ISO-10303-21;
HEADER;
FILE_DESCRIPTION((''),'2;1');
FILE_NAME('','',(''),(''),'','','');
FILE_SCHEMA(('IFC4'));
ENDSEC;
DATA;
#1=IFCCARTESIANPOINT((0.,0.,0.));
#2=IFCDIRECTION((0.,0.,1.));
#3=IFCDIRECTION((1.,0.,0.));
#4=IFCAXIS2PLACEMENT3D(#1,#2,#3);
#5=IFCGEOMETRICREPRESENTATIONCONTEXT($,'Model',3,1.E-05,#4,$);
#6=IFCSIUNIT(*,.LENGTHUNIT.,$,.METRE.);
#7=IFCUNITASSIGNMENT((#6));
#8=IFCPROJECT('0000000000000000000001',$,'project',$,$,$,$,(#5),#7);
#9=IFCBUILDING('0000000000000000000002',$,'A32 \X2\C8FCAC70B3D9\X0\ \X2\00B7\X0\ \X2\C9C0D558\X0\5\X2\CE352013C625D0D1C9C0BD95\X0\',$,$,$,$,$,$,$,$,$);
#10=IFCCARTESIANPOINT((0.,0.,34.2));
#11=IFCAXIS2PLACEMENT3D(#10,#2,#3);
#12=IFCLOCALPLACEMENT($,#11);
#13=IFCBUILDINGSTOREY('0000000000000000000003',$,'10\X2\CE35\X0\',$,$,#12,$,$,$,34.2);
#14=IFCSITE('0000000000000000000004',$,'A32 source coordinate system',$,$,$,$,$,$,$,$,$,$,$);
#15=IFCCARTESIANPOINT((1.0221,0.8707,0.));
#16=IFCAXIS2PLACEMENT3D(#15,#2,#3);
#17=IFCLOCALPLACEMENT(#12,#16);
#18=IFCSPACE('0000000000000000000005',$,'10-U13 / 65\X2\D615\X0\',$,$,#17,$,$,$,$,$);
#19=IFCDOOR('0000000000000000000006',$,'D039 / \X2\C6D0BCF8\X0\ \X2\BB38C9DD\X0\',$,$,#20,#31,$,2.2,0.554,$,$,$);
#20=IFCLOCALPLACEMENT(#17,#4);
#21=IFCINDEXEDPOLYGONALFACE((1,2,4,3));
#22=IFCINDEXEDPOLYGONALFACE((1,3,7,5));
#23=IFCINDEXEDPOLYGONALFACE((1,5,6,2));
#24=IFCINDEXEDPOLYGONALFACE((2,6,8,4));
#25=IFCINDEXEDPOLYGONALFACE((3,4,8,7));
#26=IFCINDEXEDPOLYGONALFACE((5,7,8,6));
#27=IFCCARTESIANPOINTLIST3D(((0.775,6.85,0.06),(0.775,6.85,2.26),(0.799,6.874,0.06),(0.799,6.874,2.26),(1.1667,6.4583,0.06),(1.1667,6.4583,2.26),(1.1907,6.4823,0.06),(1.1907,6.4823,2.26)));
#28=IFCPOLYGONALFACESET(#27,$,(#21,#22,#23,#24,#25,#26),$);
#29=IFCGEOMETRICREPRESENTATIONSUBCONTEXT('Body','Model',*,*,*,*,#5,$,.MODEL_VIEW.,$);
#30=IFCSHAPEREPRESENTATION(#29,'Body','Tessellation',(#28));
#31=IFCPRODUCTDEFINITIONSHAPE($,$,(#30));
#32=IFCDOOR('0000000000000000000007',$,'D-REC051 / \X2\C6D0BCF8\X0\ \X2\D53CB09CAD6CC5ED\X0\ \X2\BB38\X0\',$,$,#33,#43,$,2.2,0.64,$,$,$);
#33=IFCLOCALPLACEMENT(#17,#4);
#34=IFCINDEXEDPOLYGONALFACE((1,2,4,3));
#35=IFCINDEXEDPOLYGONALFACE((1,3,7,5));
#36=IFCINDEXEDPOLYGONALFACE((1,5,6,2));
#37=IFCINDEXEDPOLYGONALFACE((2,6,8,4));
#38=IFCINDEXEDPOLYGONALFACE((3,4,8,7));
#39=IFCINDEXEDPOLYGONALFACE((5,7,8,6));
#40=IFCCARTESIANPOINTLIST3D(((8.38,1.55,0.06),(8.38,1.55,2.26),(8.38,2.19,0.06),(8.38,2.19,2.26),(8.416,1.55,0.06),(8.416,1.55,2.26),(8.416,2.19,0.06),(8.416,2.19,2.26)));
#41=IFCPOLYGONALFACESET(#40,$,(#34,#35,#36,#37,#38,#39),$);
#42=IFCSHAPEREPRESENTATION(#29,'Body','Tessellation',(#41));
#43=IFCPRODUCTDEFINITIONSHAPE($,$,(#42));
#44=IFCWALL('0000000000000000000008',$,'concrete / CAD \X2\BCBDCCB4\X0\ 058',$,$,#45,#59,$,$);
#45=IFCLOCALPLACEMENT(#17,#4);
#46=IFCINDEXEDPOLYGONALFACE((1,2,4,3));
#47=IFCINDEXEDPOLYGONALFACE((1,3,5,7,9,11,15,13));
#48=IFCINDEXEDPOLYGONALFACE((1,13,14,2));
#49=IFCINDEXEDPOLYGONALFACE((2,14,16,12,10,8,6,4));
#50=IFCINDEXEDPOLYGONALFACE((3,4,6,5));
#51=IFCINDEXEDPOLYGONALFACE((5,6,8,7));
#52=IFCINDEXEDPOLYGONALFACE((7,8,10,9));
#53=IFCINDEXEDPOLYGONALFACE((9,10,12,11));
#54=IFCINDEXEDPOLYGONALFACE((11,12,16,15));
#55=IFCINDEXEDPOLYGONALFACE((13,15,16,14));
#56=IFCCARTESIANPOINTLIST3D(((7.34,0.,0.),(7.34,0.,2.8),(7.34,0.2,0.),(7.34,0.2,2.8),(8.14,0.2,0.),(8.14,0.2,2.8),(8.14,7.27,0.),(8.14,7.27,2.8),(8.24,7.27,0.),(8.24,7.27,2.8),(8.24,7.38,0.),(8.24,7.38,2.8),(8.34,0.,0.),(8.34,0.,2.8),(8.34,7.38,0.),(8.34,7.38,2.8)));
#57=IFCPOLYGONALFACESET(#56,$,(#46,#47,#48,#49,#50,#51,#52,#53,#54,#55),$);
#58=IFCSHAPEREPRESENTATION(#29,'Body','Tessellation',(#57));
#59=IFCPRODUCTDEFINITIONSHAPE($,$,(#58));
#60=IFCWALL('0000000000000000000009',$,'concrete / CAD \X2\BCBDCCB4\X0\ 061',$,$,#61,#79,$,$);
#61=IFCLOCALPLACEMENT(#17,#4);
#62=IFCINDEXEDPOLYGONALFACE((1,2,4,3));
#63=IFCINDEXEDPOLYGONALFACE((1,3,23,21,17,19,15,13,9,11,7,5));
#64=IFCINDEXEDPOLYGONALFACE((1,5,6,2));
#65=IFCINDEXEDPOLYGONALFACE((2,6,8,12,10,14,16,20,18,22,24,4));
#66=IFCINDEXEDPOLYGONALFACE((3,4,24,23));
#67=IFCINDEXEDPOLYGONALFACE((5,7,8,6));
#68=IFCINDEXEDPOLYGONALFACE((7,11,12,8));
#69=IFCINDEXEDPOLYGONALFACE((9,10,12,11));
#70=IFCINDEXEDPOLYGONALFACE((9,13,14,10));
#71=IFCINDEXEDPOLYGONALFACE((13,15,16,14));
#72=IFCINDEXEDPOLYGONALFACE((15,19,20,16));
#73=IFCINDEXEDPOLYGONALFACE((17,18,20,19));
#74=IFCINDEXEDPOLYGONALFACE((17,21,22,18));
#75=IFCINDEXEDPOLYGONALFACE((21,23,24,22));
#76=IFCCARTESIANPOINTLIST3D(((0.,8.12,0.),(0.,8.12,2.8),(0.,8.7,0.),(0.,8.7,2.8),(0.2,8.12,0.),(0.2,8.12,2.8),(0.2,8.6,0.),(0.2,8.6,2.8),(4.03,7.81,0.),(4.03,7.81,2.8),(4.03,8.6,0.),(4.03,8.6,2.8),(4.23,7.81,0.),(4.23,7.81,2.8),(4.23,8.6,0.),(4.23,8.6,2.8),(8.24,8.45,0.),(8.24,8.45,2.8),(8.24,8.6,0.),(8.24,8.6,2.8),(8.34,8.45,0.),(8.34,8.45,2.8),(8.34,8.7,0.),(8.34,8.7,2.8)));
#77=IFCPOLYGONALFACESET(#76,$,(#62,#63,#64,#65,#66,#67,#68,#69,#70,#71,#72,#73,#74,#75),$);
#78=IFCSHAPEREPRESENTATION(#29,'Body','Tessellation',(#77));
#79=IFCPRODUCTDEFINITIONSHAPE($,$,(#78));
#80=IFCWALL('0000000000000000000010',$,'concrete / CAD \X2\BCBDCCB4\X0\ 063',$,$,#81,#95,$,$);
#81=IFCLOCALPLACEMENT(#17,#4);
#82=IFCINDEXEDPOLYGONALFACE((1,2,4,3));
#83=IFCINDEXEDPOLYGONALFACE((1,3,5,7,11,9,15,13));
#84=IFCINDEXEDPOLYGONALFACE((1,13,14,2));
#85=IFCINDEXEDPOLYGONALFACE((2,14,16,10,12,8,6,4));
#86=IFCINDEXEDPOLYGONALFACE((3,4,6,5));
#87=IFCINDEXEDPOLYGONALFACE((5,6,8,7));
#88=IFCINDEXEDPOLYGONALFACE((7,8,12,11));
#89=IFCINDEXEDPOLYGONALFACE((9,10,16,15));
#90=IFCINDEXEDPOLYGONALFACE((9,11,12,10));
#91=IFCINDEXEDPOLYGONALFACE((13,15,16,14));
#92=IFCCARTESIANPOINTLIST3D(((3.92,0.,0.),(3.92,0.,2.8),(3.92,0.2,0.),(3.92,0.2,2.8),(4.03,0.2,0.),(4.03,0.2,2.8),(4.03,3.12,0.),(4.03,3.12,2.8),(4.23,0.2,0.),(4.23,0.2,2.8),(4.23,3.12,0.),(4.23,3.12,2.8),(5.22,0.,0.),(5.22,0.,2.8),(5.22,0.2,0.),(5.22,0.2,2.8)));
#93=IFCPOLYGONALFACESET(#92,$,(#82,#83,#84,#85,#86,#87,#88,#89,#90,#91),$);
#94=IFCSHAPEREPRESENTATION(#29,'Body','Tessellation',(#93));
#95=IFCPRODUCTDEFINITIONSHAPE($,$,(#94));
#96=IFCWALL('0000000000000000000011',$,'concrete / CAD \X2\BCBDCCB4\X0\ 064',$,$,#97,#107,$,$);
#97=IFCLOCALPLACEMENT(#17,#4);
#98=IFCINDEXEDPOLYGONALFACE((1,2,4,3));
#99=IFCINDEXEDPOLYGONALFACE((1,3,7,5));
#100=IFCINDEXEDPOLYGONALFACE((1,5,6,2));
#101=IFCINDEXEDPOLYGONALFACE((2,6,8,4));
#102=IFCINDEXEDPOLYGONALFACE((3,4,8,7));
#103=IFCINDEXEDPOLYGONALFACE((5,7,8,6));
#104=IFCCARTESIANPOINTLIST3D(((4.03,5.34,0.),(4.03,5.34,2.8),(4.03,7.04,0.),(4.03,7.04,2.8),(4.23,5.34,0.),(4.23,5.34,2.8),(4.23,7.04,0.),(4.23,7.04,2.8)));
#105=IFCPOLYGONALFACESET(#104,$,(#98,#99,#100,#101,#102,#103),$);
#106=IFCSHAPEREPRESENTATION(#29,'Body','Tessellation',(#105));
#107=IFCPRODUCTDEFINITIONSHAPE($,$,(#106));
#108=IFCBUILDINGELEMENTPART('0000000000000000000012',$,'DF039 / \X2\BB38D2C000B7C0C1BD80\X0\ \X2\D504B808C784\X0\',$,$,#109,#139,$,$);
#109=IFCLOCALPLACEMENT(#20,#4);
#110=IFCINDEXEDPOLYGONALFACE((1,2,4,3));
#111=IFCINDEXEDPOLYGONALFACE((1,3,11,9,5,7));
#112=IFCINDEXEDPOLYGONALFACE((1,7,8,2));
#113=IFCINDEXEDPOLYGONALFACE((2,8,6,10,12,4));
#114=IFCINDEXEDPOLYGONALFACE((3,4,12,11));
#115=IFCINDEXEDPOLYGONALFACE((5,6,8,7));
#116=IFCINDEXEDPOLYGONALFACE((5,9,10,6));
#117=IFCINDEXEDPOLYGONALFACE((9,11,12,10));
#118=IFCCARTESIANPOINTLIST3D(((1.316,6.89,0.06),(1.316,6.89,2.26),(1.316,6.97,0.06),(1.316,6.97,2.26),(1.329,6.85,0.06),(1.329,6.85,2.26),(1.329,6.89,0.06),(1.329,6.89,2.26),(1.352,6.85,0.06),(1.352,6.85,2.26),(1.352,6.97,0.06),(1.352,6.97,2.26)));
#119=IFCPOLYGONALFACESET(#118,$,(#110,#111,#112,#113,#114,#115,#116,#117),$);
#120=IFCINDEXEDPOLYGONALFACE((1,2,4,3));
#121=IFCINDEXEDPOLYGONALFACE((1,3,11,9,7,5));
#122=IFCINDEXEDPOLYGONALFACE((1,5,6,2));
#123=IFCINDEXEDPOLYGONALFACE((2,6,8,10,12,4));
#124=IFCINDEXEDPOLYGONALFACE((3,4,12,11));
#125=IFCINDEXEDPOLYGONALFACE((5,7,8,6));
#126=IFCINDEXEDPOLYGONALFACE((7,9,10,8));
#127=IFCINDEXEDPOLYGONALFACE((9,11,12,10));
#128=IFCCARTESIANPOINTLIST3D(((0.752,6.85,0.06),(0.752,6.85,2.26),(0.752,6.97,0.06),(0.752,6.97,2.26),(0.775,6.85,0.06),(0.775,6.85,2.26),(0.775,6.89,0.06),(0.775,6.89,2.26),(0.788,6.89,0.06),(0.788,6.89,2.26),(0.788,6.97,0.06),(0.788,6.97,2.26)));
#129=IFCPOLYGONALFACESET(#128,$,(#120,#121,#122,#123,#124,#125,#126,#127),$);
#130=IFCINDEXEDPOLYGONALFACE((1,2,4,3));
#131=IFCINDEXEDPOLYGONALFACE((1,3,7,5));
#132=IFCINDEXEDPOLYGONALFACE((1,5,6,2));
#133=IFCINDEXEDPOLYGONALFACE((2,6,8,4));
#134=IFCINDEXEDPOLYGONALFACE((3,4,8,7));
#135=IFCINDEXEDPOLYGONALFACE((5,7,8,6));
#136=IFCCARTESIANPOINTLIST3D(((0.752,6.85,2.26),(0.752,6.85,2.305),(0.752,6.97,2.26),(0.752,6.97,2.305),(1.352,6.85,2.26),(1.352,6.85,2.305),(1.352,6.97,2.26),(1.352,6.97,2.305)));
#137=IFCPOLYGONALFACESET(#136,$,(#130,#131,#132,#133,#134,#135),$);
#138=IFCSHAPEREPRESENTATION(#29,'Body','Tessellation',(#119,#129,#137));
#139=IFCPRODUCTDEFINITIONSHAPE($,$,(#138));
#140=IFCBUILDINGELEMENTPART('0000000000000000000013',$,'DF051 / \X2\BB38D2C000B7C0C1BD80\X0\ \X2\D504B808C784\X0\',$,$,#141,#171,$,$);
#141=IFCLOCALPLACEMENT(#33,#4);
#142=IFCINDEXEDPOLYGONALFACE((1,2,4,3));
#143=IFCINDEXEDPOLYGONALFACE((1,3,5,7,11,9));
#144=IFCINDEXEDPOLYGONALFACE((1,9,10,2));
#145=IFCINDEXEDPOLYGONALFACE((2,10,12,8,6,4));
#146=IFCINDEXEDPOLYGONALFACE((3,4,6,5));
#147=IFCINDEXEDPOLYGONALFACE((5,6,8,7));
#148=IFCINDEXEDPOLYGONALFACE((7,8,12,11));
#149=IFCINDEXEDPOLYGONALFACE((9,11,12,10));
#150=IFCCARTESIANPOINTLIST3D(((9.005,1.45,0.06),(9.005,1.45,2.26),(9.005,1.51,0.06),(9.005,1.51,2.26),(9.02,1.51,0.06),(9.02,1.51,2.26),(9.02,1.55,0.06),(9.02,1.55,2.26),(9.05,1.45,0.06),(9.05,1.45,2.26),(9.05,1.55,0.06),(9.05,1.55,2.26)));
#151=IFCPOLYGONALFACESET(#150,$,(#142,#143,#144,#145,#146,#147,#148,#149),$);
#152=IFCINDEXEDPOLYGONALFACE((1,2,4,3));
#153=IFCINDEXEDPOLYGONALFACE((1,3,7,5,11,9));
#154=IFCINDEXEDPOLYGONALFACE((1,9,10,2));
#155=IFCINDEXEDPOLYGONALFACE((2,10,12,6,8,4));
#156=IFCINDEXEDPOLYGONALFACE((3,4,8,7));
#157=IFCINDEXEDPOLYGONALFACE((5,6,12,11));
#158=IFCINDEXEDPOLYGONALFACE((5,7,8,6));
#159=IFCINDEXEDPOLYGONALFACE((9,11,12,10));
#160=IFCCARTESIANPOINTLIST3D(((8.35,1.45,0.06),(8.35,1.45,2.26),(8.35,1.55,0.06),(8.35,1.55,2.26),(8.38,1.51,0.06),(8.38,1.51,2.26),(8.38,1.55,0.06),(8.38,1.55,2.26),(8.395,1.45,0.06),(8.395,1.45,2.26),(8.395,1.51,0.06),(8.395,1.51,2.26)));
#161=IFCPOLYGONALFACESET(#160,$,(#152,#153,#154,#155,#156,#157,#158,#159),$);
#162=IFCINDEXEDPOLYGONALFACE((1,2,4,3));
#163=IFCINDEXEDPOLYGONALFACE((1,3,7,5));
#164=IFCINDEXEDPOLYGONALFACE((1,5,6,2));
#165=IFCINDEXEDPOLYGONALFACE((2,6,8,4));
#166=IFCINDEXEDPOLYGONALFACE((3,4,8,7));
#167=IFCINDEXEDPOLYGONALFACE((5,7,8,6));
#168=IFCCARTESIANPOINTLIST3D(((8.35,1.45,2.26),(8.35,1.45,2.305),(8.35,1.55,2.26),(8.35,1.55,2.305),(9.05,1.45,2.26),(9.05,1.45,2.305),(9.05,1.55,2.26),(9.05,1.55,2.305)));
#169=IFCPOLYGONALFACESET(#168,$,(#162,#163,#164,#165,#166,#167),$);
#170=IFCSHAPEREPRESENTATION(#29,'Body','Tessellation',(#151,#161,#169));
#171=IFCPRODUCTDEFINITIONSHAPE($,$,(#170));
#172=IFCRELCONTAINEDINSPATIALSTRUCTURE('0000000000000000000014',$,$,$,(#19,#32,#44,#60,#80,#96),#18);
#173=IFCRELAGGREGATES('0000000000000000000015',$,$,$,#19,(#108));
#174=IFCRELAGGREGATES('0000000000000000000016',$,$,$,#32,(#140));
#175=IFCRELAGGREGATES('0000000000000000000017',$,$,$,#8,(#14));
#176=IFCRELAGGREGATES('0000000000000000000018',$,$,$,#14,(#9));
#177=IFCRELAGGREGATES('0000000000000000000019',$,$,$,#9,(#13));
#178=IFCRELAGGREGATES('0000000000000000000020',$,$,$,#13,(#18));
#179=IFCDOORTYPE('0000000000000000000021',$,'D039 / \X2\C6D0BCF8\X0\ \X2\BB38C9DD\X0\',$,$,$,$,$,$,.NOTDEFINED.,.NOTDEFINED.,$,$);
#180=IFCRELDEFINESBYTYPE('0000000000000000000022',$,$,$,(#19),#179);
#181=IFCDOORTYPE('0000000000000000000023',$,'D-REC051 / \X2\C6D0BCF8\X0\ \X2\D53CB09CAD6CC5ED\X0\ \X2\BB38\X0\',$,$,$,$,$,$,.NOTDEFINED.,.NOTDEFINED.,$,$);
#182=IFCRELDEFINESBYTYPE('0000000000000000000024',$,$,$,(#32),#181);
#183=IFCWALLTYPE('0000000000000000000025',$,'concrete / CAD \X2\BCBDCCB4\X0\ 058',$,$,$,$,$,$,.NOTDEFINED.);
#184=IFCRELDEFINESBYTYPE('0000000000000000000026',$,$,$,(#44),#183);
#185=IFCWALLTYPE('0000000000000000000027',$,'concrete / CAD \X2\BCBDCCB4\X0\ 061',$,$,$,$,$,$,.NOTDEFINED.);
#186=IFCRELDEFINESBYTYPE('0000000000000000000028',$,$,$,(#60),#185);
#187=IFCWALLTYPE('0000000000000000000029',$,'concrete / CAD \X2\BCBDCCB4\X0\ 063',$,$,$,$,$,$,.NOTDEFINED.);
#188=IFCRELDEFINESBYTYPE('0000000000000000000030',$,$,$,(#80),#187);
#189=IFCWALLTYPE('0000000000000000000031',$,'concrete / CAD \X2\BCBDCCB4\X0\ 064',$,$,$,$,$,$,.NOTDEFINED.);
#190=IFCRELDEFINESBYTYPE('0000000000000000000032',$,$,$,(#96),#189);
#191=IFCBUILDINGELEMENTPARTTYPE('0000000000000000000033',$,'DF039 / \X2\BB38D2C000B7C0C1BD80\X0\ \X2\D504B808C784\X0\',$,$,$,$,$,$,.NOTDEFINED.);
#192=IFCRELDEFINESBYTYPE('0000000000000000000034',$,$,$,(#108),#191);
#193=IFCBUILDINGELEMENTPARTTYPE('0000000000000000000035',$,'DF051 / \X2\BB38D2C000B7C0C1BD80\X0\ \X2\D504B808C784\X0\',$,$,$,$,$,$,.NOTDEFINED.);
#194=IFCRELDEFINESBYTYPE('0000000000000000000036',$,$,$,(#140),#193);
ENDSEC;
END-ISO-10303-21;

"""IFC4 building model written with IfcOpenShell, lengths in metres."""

from ifc_helpers import new_model, si_unit, frame, origin, origin_with_axes, place, context, subcontext, project, spatial, polyline, outline, extrude, source, transform, mapped, type_object, type_shapes, element, aggregate, save


model = new_model("IFC4")

# Units and contexts
model_context = context("Model", 3, precision=1e-05, world=origin_with_axes())
body_context = subcontext(model_context, "Body", "Model", "MODEL_VIEW")
ifc_project = project(units=[si_unit("LENGTHUNIT", "METRE")], contexts=[model_context])

# Site, building, storey, space
storey_placement = place(None, frame((0.0, 0.0, 34.2), z_axis=(0.0, 0.0, 1.0), x_axis=(1.0, 0.0, 0.0)))
space_placement = place(storey_placement, frame((1.0221, 0.8707, 0.0), z_axis=(0.0, 0.0, 1.0), x_axis=(1.0, 0.0, 0.0)))
site = spatial("IfcSite", under=ifc_project, Name="A32 source coordinate system")
building = spatial("IfcBuilding", under=site, Name="A32 주거동 · 지하5층–옥탑지붕")
storey = spatial("IfcBuildingStorey", under=building, at=storey_placement, Name="10층", Elevation=34.2)
space = spatial("IfcSpace", under=storey, at=space_placement, Name="10-U13 / 65형")

# Doors
door_type_1 = type_object("IfcDoorType", Name="D039 / 원본 문짝", OperationType="NOTDEFINED", PredefinedType="NOTDEFINED")
shared_shape_1 = source(origin(), body_context, "Body", "SweptSolid", [
    extrude(outline(polyline([(1.1907, 6.4823), (1.1667, 6.4583), (0.775, 6.85), (0.799, 6.874), (1.1907, 6.4823)])), frame((0.0, 0.0, 0.06)), (0.0, 0.0, 1.0), 2.2),
])
type_shapes(door_type_1, [shared_shape_1])
door_1_placement = place(space_placement, origin_with_axes())
door_1 = element("IfcDoor", 1, at=door_1_placement, inside=space, type_object=door_type_1, Name="D039 / 원본 문짝", OverallHeight=2.2, OverallWidth=0.554, context=body_context, shape_type="MappedRepresentation", body=[
    mapped(shared_shape_1, transform((0.0, 0.0, 0.0), scale=1.0)),
])
door_type_2 = type_object("IfcDoorType", Name="D-REC051 / 원본 피난구역 문", OperationType="NOTDEFINED", PredefinedType="NOTDEFINED")
shared_shape_2 = source(origin(), body_context, "Body", "SweptSolid", [
    extrude(outline(polyline([(8.416, 2.19), (8.416, 1.55), (8.38, 1.55), (8.38, 2.19), (8.416, 2.19)])), frame((0.0, 0.0, 0.06)), (0.0, 0.0, 1.0), 2.2),
])
type_shapes(door_type_2, [shared_shape_2])
door_2_placement = place(space_placement, origin_with_axes())
door_2 = element("IfcDoor", 2, at=door_2_placement, inside=space, type_object=door_type_2, Name="D-REC051 / 원본 피난구역 문", OverallHeight=2.2, OverallWidth=0.64, context=body_context, shape_type="MappedRepresentation", body=[
    mapped(shared_shape_2, transform((0.0, 0.0, 0.0), scale=1.0)),
])

# Walls
wall_type_1 = type_object("IfcWallType", Name="concrete / CAD 벽체 058", PredefinedType="NOTDEFINED")
shared_shape_3 = source(origin(), body_context, "Body", "SweptSolid", [
    extrude(outline(polyline([(8.34, 0.0), (7.34, 0.0), (7.34, 0.2), (8.14, 0.2), (8.14, 7.27), (8.24, 7.27), (8.24, 7.38), (8.34, 7.38), (8.34, 0.0)])), origin(), (0.0, 0.0, 1.0), 2.8),
])
type_shapes(wall_type_1, [shared_shape_3])
wall_1_placement = place(space_placement, origin_with_axes())
element("IfcWall", 3, at=wall_1_placement, inside=space, type_object=wall_type_1, Name="concrete / CAD 벽체 058", context=body_context, shape_type="MappedRepresentation", body=[
    mapped(shared_shape_3, transform((0.0, 0.0, 0.0), scale=1.0)),
])
wall_type_2 = type_object("IfcWallType", Name="concrete / CAD 벽체 061", PredefinedType="NOTDEFINED")
shared_shape_4 = source(origin(), body_context, "Body", "SweptSolid", [
    extrude(outline(polyline([(0.2, 8.6), (0.2, 8.12), (0.0, 8.12), (0.0, 8.7), (8.34, 8.7), (8.34, 8.45), (8.24, 8.45), (8.24, 8.6), (4.23, 8.6), (4.23, 7.81), (4.03, 7.81), (4.03, 8.6), (0.2, 8.6)])), origin(), (0.0, 0.0, 1.0), 2.8),
])
type_shapes(wall_type_2, [shared_shape_4])
wall_2_placement = place(space_placement, origin_with_axes())
element("IfcWall", 4, at=wall_2_placement, inside=space, type_object=wall_type_2, Name="concrete / CAD 벽체 061", context=body_context, shape_type="MappedRepresentation", body=[
    mapped(shared_shape_4, transform((0.0, 0.0, 0.0), scale=1.0)),
])
wall_type_3 = type_object("IfcWallType", Name="concrete / CAD 벽체 063", PredefinedType="NOTDEFINED")
shared_shape_5 = source(origin(), body_context, "Body", "SweptSolid", [
    extrude(outline(polyline([(5.22, 0.0), (3.92, 0.0), (3.92, 0.2), (4.03, 0.2), (4.03, 3.12), (4.23, 3.12), (4.23, 0.2), (5.22, 0.2), (5.22, 0.0)])), origin(), (0.0, 0.0, 1.0), 2.8),
])
type_shapes(wall_type_3, [shared_shape_5])
wall_3_placement = place(space_placement, origin_with_axes())
element("IfcWall", 5, at=wall_3_placement, inside=space, type_object=wall_type_3, Name="concrete / CAD 벽체 063", context=body_context, shape_type="MappedRepresentation", body=[
    mapped(shared_shape_5, transform((0.0, 0.0, 0.0), scale=1.0)),
])
wall_type_4 = type_object("IfcWallType", Name="concrete / CAD 벽체 064", PredefinedType="NOTDEFINED")
shared_shape_6 = source(origin(), body_context, "Body", "SweptSolid", [
    extrude(outline(polyline([(4.03, 7.04), (4.23, 7.04), (4.23, 5.34), (4.03, 5.34), (4.03, 7.04)])), origin(), (0.0, 0.0, 1.0), 2.8),
])
type_shapes(wall_type_4, [shared_shape_6])
wall_4_placement = place(space_placement, origin_with_axes())
element("IfcWall", 6, at=wall_4_placement, inside=space, type_object=wall_type_4, Name="concrete / CAD 벽체 064", context=body_context, shape_type="MappedRepresentation", body=[
    mapped(shared_shape_6, transform((0.0, 0.0, 0.0), scale=1.0)),
])

# Building element parts
building_element_part_type_1 = type_object("IfcBuildingElementPartType", Name="DF039 / 문틀·상부 프레임", PredefinedType="NOTDEFINED")
shared_shape_7 = source(origin(), body_context, "Body", "SweptSolid", [
    extrude(outline(polyline([(1.352, 6.85), (1.329, 6.85), (1.329, 6.89), (1.316, 6.89), (1.316, 6.97), (1.352, 6.97), (1.352, 6.85)])), frame((0.0, 0.0, 0.06)), (0.0, 0.0, 1.0), 2.2),
    extrude(outline(polyline([(0.788, 6.97), (0.788, 6.89), (0.775, 6.89), (0.775, 6.85), (0.752, 6.85), (0.752, 6.97), (0.788, 6.97)])), frame((0.0, 0.0, 0.06)), (0.0, 0.0, 1.0), 2.2),
    extrude(outline(polyline([(0.752, 6.85), (0.752, 6.97), (1.352, 6.97), (1.352, 6.85), (0.752, 6.85)])), frame((0.0, 0.0, 2.26)), (0.0, 0.0, 1.0), 0.045),
])
type_shapes(building_element_part_type_1, [shared_shape_7])
building_element_part_1_placement = place(door_1_placement, origin_with_axes())
building_element_part_1 = element("IfcBuildingElementPart", 7, at=building_element_part_1_placement, type_object=building_element_part_type_1, Name="DF039 / 문틀·상부 프레임", context=body_context, shape_type="MappedRepresentation", body=[
    mapped(shared_shape_7, transform((0.0, 0.0, 0.0), scale=1.0)),
])
aggregate(door_1, [building_element_part_1])
building_element_part_type_2 = type_object("IfcBuildingElementPartType", Name="DF051 / 문틀·상부 프레임", PredefinedType="NOTDEFINED")
shared_shape_8 = source(origin(), body_context, "Body", "SweptSolid", [
    extrude(outline(polyline([(9.05, 1.45), (9.005, 1.45), (9.005, 1.51), (9.02, 1.51), (9.02, 1.55), (9.05, 1.55), (9.05, 1.45)])), frame((0.0, 0.0, 0.06)), (0.0, 0.0, 1.0), 2.2),
    extrude(outline(polyline([(8.38, 1.55), (8.38, 1.51), (8.395, 1.51), (8.395, 1.45), (8.35, 1.45), (8.35, 1.55), (8.38, 1.55)])), frame((0.0, 0.0, 0.06)), (0.0, 0.0, 1.0), 2.2),
    extrude(outline(polyline([(8.35, 1.45), (8.35, 1.55), (9.05, 1.55), (9.05, 1.45), (8.35, 1.45)])), frame((0.0, 0.0, 2.26)), (0.0, 0.0, 1.0), 0.045),
])
type_shapes(building_element_part_type_2, [shared_shape_8])
building_element_part_2_placement = place(door_2_placement, origin_with_axes())
building_element_part_2 = element("IfcBuildingElementPart", 8, at=building_element_part_2_placement, type_object=building_element_part_type_2, Name="DF051 / 문틀·상부 프레임", context=body_context, shape_type="MappedRepresentation", body=[
    mapped(shared_shape_8, transform((0.0, 0.0, 0.0), scale=1.0)),
])
aggregate(door_2, [building_element_part_2])

save(model, "model.ifc")
